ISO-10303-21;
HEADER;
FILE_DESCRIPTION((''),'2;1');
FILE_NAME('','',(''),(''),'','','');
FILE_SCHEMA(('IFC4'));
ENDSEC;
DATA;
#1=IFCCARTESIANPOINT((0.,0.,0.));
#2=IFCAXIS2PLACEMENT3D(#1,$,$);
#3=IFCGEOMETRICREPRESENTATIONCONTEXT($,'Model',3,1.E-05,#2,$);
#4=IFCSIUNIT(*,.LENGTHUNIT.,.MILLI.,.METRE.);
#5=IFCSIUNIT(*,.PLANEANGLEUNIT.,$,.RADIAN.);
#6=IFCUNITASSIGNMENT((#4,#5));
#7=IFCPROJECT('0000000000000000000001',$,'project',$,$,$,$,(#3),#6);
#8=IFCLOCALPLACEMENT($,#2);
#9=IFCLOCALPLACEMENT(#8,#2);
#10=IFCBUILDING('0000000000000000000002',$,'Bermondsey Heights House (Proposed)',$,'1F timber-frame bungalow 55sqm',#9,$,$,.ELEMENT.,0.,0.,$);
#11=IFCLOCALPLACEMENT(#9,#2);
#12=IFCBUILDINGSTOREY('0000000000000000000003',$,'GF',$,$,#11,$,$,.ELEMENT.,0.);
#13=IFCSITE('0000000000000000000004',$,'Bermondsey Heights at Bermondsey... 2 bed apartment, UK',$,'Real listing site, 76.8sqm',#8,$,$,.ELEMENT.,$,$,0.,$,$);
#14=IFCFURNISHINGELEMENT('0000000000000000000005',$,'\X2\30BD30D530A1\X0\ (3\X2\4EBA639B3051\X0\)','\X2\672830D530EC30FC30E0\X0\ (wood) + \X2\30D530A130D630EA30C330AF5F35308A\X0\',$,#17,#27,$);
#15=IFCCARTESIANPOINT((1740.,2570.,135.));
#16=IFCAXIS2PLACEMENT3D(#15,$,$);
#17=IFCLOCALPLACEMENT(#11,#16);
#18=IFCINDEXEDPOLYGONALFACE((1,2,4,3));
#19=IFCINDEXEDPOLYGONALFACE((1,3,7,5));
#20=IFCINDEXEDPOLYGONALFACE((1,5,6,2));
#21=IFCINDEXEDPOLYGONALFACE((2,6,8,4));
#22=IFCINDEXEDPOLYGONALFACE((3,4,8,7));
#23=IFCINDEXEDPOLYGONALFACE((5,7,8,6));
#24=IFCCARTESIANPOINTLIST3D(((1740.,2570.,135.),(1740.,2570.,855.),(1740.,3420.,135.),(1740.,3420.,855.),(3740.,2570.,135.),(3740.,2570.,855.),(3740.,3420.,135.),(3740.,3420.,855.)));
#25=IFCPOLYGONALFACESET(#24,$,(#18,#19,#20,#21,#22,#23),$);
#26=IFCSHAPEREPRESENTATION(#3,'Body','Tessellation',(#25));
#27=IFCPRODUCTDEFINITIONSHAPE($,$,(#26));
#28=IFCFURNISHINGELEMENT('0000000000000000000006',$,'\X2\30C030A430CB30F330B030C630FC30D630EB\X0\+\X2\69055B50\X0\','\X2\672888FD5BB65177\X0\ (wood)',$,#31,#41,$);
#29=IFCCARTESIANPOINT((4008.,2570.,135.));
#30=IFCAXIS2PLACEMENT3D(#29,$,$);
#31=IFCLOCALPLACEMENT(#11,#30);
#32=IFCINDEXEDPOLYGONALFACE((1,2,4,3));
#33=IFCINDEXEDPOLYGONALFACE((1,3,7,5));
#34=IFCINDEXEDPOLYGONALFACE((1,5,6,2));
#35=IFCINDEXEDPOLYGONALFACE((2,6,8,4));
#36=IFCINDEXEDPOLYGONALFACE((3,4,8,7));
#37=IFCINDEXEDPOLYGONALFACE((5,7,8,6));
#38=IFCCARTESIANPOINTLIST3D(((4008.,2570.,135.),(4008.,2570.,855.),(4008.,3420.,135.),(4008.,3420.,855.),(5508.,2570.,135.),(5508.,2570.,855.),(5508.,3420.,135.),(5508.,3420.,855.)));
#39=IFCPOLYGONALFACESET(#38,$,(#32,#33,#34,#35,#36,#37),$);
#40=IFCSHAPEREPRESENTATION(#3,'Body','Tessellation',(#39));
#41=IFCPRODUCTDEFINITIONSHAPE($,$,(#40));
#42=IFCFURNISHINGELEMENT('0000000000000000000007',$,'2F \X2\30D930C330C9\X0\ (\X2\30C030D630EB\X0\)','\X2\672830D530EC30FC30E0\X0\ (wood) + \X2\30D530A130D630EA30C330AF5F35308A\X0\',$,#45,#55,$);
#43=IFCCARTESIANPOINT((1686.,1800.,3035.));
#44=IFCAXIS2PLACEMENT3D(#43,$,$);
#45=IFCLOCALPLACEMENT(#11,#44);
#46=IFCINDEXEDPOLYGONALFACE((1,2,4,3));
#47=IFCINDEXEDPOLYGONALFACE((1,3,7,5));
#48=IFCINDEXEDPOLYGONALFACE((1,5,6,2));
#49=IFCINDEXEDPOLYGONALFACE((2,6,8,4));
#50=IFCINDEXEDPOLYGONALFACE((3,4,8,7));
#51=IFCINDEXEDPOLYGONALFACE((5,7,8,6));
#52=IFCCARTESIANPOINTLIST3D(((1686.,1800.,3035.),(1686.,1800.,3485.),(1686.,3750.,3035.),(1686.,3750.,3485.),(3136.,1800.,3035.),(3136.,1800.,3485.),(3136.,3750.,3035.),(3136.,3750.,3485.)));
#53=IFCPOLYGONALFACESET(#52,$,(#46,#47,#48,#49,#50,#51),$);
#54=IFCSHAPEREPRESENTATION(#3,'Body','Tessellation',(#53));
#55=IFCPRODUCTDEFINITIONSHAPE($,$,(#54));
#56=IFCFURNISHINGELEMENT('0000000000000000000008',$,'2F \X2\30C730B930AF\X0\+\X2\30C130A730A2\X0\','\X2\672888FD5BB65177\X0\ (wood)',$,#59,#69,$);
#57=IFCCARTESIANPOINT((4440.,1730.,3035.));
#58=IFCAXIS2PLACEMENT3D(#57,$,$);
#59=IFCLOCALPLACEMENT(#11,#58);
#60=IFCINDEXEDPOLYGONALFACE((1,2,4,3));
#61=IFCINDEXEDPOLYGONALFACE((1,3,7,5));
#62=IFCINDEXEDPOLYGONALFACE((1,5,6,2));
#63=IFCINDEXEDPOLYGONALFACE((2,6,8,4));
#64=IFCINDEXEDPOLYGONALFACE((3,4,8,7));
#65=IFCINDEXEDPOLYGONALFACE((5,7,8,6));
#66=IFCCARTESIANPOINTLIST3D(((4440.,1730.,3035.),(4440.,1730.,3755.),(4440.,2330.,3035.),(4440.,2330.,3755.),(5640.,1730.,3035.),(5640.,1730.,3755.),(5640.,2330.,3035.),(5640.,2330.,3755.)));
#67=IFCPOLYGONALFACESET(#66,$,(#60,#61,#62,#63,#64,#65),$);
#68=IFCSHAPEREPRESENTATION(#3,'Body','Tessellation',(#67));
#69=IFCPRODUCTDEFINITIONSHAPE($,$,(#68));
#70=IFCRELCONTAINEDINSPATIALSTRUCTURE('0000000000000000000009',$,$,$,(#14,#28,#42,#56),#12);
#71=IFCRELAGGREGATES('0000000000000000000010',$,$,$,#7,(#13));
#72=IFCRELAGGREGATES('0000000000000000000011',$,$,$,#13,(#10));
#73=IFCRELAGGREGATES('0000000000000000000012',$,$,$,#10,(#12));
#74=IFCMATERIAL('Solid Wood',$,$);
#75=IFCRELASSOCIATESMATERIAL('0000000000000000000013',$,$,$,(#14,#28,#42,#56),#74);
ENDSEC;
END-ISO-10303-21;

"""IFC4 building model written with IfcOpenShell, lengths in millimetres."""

from ifc_helpers import new_model, si_unit, frame, frame_2d, origin, place, context, project, spatial, rectangle, extrude, material, element, save


model = new_model("IFC4")

# Units and contexts
model_context = context("Model", 3, precision=1e-05, world=origin())
ifc_project = project(units=[si_unit("LENGTHUNIT", "METRE", prefix="MILLI"), si_unit("PLANEANGLEUNIT", "RADIAN")], contexts=[model_context])

# Site, building, storey
site_placement = place(None, origin())
site = spatial("IfcSite", under=ifc_project, at=site_placement, Name="Bermondsey Heights at Bermondsey... 2 bed apartment, UK", ObjectType="Real listing site, 76.8sqm", CompositionType="ELEMENT", RefElevation=0.0)
building_placement = place(site_placement, origin())
building = spatial("IfcBuilding", under=site, at=building_placement, Name="Bermondsey Heights House (Proposed)", ObjectType="1F timber-frame bungalow 55sqm", CompositionType="ELEMENT", ElevationOfRefHeight=0.0, ElevationOfTerrain=0.0)
storey_placement = place(building_placement, origin())
storey = spatial("IfcBuildingStorey", under=building, at=storey_placement, Name="GF", CompositionType="ELEMENT", Elevation=0.0)

# Shared definitions
ifc_material_1 = material(Name="Solid Wood")

# Furnishing elements
furnishing_1_placement = place(storey_placement, frame((1740.0, 2570.0, 135.0)))
element("IfcFurnishingElement", 1, at=furnishing_1_placement, inside=storey, material=ifc_material_1, Name="ソファ (3人掛け)", Description="木フレーム (wood) + ファブリック張り", context=model_context, shape_type="SweptSolid", body=[
    extrude(rectangle(XDim=2000.0, YDim=850.0, at=frame_2d((1000.0, 425.0))), frame((1740.0, 2570.0, 135.0)), (0.0, 0.0, 1.0), 720.0),
])
furnishing_2_placement = place(storey_placement, frame((4008.0, 2570.0, 135.0)))
element("IfcFurnishingElement", 2, at=furnishing_2_placement, inside=storey, material=ifc_material_1, Name="ダイニングテーブル+椅子", Description="木製家具 (wood)", context=model_context, shape_type="SweptSolid", body=[
    extrude(rectangle(XDim=1500.0, YDim=850.0, at=frame_2d((750.0, 425.0))), frame((4008.0, 2570.0, 135.0)), (0.0, 0.0, 1.0), 720.0),
])
furnishing_3_placement = place(storey_placement, frame((1686.0, 1800.0, 3035.0)))
element("IfcFurnishingElement", 3, at=furnishing_3_placement, inside=storey, material=ifc_material_1, Name="2F ベッド (ダブル)", Description="木フレーム (wood) + ファブリック張り", context=model_context, shape_type="SweptSolid", body=[
    extrude(rectangle(XDim=1450.0, YDim=1950.0, at=frame_2d((725.0, 975.0))), frame((1686.0, 1800.0, 3035.0)), (0.0, 0.0, 1.0), 450.0),
])
furnishing_4_placement = place(storey_placement, frame((4440.0, 1730.0, 3035.0)))
element("IfcFurnishingElement", 4, at=furnishing_4_placement, inside=storey, material=ifc_material_1, Name="2F デスク+チェア", Description="木製家具 (wood)", context=model_context, shape_type="SweptSolid", body=[
    extrude(rectangle(XDim=1200.0, YDim=600.0, at=frame_2d((600.0, 300.0))), frame((4440.0, 1730.0, 3035.0)), (0.0, 0.0, 1.0), 720.0),
])

save(model, "model.ifc")
